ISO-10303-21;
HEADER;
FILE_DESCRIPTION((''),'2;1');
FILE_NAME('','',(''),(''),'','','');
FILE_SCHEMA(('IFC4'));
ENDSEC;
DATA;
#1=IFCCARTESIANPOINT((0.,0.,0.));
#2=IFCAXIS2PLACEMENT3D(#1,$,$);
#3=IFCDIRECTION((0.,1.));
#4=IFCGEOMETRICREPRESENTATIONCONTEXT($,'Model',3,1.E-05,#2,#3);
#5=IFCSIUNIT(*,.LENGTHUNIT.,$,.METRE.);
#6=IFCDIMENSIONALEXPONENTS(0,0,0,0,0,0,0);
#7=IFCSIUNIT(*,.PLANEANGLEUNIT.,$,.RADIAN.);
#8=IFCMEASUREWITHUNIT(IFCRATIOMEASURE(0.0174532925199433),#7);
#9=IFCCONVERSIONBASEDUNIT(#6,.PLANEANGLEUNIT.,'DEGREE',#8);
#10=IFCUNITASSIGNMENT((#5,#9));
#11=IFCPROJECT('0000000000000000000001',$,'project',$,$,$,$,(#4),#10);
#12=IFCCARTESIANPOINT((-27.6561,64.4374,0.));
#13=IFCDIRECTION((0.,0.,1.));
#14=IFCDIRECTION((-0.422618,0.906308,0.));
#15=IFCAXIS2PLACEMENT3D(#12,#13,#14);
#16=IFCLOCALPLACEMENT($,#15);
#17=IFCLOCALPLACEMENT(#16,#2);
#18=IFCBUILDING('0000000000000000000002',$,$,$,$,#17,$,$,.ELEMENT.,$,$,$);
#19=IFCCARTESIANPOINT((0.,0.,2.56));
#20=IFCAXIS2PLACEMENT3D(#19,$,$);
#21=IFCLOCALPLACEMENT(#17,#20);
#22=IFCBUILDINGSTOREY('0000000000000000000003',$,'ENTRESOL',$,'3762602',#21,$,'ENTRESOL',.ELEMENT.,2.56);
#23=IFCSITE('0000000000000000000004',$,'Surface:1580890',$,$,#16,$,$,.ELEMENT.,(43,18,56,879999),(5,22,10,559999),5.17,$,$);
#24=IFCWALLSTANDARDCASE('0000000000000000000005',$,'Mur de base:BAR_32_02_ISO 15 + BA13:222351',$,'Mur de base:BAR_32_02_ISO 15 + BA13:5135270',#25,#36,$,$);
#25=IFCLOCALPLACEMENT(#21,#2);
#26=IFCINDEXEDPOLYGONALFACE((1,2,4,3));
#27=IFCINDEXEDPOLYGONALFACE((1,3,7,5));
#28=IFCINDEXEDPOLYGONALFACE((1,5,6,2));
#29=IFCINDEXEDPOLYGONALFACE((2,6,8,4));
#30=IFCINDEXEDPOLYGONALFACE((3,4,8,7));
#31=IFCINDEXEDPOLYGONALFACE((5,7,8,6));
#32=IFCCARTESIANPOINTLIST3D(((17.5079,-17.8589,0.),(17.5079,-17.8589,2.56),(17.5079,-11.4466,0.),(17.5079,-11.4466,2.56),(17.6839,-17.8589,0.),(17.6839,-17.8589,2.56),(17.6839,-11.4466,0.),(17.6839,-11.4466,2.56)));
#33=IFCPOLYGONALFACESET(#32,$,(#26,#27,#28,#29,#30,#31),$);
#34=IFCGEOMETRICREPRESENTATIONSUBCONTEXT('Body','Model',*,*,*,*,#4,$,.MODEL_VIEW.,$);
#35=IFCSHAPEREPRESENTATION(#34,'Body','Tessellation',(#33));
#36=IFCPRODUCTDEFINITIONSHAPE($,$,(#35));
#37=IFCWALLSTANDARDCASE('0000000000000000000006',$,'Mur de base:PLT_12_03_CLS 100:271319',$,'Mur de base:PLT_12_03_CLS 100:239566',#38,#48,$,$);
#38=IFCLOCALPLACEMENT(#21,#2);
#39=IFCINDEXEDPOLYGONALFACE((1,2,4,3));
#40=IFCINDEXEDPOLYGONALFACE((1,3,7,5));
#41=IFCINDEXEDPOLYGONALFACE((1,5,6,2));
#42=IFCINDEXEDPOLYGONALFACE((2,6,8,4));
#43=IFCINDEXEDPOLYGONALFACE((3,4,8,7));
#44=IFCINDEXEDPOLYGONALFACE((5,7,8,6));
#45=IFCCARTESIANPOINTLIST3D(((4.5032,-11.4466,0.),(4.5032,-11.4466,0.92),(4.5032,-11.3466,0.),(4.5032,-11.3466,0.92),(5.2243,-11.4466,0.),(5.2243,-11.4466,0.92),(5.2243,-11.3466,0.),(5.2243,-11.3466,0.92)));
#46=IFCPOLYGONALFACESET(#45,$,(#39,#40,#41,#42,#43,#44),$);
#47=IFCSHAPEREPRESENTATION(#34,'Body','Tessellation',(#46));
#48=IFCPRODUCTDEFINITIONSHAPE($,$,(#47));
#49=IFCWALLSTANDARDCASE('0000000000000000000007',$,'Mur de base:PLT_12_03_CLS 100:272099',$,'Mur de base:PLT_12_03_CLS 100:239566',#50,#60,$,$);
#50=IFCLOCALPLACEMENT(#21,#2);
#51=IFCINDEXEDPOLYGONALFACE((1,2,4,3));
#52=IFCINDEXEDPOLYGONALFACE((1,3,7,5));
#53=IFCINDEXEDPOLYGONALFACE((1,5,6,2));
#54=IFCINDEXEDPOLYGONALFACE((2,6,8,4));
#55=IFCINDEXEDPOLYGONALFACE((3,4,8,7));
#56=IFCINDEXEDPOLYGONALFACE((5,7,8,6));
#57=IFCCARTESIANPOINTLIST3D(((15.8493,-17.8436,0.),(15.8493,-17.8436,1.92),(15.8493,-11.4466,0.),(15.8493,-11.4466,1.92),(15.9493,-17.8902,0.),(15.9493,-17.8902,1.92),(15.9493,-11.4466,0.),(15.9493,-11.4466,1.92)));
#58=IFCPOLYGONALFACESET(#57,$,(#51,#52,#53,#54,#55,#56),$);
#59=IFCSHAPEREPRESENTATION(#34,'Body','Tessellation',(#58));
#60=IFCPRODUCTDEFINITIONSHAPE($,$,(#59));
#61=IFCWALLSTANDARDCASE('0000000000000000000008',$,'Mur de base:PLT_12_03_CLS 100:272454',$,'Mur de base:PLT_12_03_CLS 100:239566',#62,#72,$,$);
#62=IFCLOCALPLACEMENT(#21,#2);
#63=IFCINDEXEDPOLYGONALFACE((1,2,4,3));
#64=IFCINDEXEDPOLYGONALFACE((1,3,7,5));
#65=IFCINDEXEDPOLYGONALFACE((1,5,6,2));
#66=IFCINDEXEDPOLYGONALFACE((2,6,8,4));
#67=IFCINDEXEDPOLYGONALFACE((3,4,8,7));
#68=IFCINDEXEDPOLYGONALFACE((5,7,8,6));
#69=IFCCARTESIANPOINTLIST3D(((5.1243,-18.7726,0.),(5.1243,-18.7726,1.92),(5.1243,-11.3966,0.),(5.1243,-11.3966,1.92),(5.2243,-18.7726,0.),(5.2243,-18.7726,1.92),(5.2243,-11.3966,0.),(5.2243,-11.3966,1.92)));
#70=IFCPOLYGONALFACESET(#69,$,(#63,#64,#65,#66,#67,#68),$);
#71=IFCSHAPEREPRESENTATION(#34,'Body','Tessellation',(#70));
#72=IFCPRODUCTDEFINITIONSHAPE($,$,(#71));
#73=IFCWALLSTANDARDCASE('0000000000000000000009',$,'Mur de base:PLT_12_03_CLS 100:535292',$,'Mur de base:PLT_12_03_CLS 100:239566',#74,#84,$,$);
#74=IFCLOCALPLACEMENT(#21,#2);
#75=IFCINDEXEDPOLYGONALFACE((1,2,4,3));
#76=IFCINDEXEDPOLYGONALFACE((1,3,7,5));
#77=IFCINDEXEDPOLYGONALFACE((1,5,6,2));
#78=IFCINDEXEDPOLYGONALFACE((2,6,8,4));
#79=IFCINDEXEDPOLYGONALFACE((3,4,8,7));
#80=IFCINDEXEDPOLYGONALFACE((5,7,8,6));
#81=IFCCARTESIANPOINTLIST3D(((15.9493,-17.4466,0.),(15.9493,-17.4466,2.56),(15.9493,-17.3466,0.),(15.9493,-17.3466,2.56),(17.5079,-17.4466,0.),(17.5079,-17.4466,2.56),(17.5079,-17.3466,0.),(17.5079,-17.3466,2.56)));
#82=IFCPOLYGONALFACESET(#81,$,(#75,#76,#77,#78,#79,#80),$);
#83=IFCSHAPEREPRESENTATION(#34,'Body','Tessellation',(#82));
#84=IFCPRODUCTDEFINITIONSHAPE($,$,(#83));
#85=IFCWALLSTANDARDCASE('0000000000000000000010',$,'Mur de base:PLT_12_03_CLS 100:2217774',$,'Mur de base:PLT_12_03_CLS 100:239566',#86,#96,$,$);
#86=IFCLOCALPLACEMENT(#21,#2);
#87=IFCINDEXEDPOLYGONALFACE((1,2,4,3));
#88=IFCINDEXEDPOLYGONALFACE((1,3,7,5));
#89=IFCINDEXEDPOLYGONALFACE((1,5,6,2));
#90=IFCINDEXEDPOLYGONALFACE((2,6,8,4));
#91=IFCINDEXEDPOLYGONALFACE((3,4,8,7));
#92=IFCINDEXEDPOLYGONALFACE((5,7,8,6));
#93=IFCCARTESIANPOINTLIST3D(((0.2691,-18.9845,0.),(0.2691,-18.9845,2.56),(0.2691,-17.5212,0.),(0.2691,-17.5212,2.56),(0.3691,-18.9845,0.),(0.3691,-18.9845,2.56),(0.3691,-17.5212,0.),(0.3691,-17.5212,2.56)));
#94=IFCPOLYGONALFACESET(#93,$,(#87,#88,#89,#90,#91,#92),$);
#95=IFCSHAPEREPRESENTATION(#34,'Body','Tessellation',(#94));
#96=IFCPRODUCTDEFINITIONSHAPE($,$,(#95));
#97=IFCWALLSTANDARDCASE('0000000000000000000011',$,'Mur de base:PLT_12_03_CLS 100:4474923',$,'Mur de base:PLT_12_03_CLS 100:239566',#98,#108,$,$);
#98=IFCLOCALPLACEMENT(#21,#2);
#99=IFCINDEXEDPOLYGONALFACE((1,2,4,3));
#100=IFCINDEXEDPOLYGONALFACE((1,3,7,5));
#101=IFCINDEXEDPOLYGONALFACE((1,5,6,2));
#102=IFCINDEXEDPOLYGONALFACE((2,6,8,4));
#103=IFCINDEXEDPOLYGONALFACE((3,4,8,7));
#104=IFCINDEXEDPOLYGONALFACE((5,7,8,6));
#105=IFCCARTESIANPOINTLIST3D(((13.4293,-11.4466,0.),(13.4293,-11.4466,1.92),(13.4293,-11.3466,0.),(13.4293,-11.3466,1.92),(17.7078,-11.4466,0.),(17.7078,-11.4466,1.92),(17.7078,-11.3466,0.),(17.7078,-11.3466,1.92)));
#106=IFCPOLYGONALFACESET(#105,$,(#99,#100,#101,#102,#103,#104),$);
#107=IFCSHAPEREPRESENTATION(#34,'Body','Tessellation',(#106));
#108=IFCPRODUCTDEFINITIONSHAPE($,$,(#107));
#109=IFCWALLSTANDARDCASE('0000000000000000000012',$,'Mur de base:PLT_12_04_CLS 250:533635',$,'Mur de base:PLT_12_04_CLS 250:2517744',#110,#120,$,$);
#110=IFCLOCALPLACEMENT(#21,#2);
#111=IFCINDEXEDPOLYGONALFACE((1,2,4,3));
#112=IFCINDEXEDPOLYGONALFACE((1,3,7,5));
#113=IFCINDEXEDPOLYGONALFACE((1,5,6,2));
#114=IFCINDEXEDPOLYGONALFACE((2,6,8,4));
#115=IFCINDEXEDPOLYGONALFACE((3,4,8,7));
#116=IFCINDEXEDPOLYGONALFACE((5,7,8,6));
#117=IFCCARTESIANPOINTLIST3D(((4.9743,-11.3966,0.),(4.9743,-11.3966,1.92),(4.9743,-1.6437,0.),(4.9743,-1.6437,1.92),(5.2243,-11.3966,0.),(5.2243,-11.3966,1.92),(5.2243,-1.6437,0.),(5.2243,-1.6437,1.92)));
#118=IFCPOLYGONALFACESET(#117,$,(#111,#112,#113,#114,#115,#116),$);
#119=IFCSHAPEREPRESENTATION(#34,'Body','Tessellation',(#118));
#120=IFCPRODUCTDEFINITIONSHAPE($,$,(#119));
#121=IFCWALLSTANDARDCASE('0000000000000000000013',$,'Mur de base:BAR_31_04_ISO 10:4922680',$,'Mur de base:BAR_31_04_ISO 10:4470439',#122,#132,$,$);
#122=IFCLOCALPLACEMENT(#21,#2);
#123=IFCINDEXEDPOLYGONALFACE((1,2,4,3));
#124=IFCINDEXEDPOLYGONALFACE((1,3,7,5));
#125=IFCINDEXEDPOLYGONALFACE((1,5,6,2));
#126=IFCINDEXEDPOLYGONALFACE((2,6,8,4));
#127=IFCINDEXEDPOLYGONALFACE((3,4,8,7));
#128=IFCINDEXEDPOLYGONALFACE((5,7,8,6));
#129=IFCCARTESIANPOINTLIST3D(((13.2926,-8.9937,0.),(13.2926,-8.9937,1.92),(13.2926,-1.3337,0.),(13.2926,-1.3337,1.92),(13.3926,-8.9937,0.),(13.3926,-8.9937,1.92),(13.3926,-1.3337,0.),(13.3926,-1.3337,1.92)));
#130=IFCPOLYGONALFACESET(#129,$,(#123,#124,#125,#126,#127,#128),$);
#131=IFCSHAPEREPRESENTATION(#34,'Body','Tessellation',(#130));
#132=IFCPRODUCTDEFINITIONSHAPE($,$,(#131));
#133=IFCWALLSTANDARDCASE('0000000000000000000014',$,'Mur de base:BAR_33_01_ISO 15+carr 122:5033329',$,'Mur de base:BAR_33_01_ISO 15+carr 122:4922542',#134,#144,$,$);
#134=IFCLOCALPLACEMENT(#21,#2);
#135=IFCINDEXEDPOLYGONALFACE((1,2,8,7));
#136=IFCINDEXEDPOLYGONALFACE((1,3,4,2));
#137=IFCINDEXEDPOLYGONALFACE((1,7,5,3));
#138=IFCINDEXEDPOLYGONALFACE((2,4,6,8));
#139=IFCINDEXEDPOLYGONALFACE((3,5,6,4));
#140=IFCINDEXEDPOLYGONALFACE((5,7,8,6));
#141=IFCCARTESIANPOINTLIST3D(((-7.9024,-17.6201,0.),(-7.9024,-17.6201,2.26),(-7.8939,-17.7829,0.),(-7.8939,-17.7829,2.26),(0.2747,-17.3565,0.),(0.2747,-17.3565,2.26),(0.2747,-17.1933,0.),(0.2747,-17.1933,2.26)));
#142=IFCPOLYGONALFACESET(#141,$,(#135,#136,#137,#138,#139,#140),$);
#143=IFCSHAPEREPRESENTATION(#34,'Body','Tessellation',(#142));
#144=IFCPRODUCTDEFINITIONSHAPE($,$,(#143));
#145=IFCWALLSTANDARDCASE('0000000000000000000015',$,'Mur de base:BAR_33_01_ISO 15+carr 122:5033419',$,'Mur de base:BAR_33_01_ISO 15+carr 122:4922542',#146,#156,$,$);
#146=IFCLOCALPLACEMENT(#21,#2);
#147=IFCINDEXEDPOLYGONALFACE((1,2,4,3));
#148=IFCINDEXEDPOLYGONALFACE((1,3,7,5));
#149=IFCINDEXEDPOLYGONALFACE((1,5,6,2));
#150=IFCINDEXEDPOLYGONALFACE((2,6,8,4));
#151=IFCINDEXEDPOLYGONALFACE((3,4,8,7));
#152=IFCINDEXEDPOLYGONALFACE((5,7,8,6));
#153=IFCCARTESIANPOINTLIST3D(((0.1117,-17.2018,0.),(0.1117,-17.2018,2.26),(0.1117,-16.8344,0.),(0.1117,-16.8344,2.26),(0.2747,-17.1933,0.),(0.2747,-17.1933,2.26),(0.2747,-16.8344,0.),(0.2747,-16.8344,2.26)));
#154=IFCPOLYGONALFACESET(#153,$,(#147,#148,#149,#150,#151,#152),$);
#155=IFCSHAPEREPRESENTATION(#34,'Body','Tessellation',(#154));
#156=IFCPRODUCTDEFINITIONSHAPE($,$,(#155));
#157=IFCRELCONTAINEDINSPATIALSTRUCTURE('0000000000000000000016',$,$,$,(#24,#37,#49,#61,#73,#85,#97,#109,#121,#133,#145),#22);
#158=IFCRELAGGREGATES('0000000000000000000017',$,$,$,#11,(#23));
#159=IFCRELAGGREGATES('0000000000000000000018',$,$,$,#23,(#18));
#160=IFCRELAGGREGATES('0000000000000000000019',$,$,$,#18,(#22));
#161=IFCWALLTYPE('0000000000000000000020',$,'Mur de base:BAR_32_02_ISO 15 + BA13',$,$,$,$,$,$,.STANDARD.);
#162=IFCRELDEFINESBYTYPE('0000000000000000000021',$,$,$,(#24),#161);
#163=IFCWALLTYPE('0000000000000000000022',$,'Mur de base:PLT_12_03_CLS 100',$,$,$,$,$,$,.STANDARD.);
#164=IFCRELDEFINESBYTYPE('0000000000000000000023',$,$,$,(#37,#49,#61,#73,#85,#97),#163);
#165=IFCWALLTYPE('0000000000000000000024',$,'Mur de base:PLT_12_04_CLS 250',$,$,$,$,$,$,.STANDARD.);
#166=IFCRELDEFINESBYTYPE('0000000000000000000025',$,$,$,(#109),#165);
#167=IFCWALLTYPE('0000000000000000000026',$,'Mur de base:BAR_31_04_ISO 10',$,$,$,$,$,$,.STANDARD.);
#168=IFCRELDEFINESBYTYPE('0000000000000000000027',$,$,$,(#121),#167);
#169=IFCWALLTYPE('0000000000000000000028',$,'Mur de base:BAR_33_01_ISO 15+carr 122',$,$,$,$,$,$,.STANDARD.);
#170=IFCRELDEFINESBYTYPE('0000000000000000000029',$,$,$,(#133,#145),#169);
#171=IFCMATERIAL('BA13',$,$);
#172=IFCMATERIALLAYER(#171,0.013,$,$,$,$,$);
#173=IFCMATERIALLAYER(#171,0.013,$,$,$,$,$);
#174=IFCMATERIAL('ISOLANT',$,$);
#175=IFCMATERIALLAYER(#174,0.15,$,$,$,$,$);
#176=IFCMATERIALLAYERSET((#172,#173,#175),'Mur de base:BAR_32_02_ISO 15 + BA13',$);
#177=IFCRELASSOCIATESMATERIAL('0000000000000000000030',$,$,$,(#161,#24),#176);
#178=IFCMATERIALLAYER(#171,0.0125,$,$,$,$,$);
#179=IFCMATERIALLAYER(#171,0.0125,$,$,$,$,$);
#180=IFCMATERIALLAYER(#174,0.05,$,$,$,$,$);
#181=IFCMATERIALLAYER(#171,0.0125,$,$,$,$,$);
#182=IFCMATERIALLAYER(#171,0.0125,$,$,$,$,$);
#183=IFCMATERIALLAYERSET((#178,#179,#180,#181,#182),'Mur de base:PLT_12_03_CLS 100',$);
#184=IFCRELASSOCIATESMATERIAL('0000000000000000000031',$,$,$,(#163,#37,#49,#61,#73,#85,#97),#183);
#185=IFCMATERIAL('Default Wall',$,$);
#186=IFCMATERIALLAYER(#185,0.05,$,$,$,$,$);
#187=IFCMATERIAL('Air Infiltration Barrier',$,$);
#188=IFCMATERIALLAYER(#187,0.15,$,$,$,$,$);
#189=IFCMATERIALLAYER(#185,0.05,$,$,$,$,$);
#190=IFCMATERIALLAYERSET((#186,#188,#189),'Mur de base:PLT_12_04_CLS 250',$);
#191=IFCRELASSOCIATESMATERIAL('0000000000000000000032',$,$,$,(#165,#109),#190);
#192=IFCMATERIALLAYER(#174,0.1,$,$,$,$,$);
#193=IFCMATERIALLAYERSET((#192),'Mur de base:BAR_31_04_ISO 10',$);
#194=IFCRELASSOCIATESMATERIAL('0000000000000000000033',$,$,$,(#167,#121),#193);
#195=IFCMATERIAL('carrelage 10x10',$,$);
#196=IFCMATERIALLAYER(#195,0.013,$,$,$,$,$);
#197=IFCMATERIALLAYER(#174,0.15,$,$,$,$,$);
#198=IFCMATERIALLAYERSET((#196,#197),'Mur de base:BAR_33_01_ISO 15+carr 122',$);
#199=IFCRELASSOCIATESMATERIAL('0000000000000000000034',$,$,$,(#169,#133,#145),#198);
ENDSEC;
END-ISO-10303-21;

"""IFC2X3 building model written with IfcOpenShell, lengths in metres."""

from ifc_helpers import new_model, entity, si_unit, converted_unit, direction, frame, frame_2d, origin, place, context, subcontext, project, spatial, polyline, rectangle, outline, extrude, clip, halfspace, bounded_halfspace, material, layer, layer_set, layer_usage, type_object, element, save


model = new_model("IFC2X3")

# Units and contexts
model_context = context("Model", 3, precision=1e-05, world=origin(), true_north=direction((0.0, 1.0)))
body_context = subcontext(model_context, "Body", "Model", "MODEL_VIEW")
ifc_project = project(units=[si_unit("LENGTHUNIT", "METRE"), converted_unit("PLANEANGLEUNIT", "DEGREE", entity("IfcRatioMeasure", 0.0174532925199433), si_unit("PLANEANGLEUNIT", "RADIAN"), dimensions=[0, 0, 0, 0, 0, 0, 0])], contexts=[model_context])

# Site, building, storey
site_placement = place(None, frame((-27.6561, 64.4374, 0.0), z_axis=(0.0, 0.0, 1.0), x_axis=(-0.422618, 0.906308, 0.0)))
site = spatial("IfcSite", under=ifc_project, at=site_placement, Name="Surface:1580890", CompositionType="ELEMENT", RefLatitude=(43, 18, 56, 879999), RefLongitude=(5, 22, 10, 559999), RefElevation=5.17)
building_placement = place(site_placement, origin())
building = spatial("IfcBuilding", under=site, at=building_placement, CompositionType="ELEMENT")
storey_placement = place(building_placement, frame((0.0, 0.0, 2.56)))
storey = spatial("IfcBuildingStorey", under=building, at=storey_placement, Name="ENTRESOL", ObjectType="3762602", LongName="ENTRESOL", CompositionType="ELEMENT", Elevation=2.56)

# Walls
ifc_material_1 = material(Name="BA13")
ifc_layer_1 = layer(ifc_material_1, 0.013)
ifc_layer_2 = layer(ifc_material_1, 0.013)
ifc_material_2 = material(Name="ISOLANT")
ifc_layer_3 = layer(ifc_material_2, 0.15)
ifc_layer_set_1 = layer_set([ifc_layer_1, ifc_layer_2, ifc_layer_3], Name="Mur de base:BAR_32_02_ISO 15 + BA13")
ifc_layer_usage_1 = layer_usage(ifc_layer_set_1, "AXIS2", "NEGATIVE", 0.088)
wall_type_1 = type_object("IfcWallType", Name="Mur de base:BAR_32_02_ISO 15 + BA13", PredefinedType="STANDARD", material=ifc_layer_set_1)
wall_1_placement = place(storey_placement, frame((17.5959, -17.8589, 0.0), z_axis=(0.0, 0.0, 1.0), x_axis=(0.0, 1.0, 0.0)))
element("IfcWallStandardCase", 1, at=wall_1_placement, inside=storey, type_object=wall_type_1, material=ifc_layer_usage_1, Name="Mur de base:BAR_32_02_ISO 15 + BA13:222351", ObjectType="Mur de base:BAR_32_02_ISO 15 + BA13:5135270", context=body_context, shape_type="Clipping", body=[
    clip(extrude(rectangle(XDim=6.4123, YDim=0.176, at=frame_2d((3.2062, 0.0), x_axis=(-1.0, 0.0))), origin(), (0.0, 0.0, 1.0), 2.56), halfspace(frame((0.0, 0.0, -2.56)), True)),
])
ifc_layer_4 = layer(ifc_material_1, 0.0125)
ifc_layer_5 = layer(ifc_material_1, 0.0125)
ifc_layer_6 = layer(ifc_material_2, 0.05)
ifc_layer_7 = layer(ifc_material_1, 0.0125)
ifc_layer_8 = layer(ifc_material_1, 0.0125)
ifc_layer_set_2 = layer_set([ifc_layer_4, ifc_layer_5, ifc_layer_6, ifc_layer_7, ifc_layer_8], Name="Mur de base:PLT_12_03_CLS 100")
ifc_layer_usage_2 = layer_usage(ifc_layer_set_2, "AXIS2", "NEGATIVE", 0.05)
wall_type_2 = type_object("IfcWallType", Name="Mur de base:PLT_12_03_CLS 100", PredefinedType="STANDARD", material=ifc_layer_set_2)
wall_2_placement = place(storey_placement, frame((4.5032, -11.3966, 0.0)))
element("IfcWallStandardCase", 2, at=wall_2_placement, inside=storey, type_object=wall_type_2, material=ifc_layer_usage_2, Name="Mur de base:PLT_12_03_CLS 100:271319", ObjectType="Mur de base:PLT_12_03_CLS 100:239566", context=body_context, shape_type="Clipping", body=[
    clip(extrude(rectangle(XDim=0.7212, YDim=0.1, at=frame_2d((0.3606, 0.0), x_axis=(-1.0, 0.0))), origin(), (0.0, 0.0, 1.0), 0.92), halfspace(frame((0.0, 0.0, -2.56)), True)),
])
ifc_layer_usage_3 = layer_usage(ifc_layer_set_2, "AXIS2", "NEGATIVE", 0.05)
wall_3_placement = place(storey_placement, frame((15.8993, -11.4466, 0.0), z_axis=(0.0, 0.0, 1.0), x_axis=(0.0, -1.0, 0.0)))
element("IfcWallStandardCase", 3, at=wall_3_placement, inside=storey, type_object=wall_type_2, material=ifc_layer_usage_3, Name="Mur de base:PLT_12_03_CLS 100:272099", ObjectType="Mur de base:PLT_12_03_CLS 100:239566", context=body_context, shape_type="Clipping", body=[
    clip(clip(extrude(outline(polyline([(0.0, -0.05), (0.1471, -0.05), (6.397, -0.05), (6.4436, 0.05), (0.1471, 0.05), (0.0, 0.05), (0.0, -0.05)])), origin(), (0.0, 0.0, 1.0), 1.92), bounded_halfspace(frame((0.0, -0.05, 1.92), z_axis=(0.0, 0.0, 1.0), x_axis=(0.0, -1.0, 0.0)), False, frame((0.0, -0.05, 1.92)), polyline([(0.0, 0.0), (0.1471, 0.0), (6.397, 0.0), (6.4436, 0.1), (0.1471, 0.1), (0.0, 0.1), (0.0, 0.0)]))), halfspace(frame((0.0, 0.0, -2.56)), True)),
])
ifc_layer_usage_4 = layer_usage(ifc_layer_set_2, "AXIS2", "NEGATIVE", 0.05)
wall_4_placement = place(storey_placement, frame((5.1743, -11.3966, 0.0), z_axis=(0.0, 0.0, 1.0), x_axis=(0.0, -1.0, 0.0)))
element("IfcWallStandardCase", 4, at=wall_4_placement, inside=storey, type_object=wall_type_2, material=ifc_layer_usage_4, Name="Mur de base:PLT_12_03_CLS 100:272454", ObjectType="Mur de base:PLT_12_03_CLS 100:239566", context=body_context, shape_type="Clipping", body=[
    clip(extrude(rectangle(XDim=7.376, YDim=0.1, at=frame_2d((3.688, 0.0), x_axis=(1.0, 0.0))), origin(), (0.0, 0.0, 1.0), 1.92), halfspace(frame((0.0, 0.0, -2.56)), True)),
])
ifc_layer_usage_5 = layer_usage(ifc_layer_set_2, "AXIS2", "NEGATIVE", 0.05)
wall_5_placement = place(storey_placement, frame((15.9493, -17.3966, 0.0)))
element("IfcWallStandardCase", 5, at=wall_5_placement, inside=storey, type_object=wall_type_2, material=ifc_layer_usage_5, Name="Mur de base:PLT_12_03_CLS 100:535292", ObjectType="Mur de base:PLT_12_03_CLS 100:239566", context=body_context, shape_type="Clipping", body=[
    clip(extrude(rectangle(XDim=1.5586, YDim=0.1, at=frame_2d((0.7793, 0.0), x_axis=(-1.0, 0.0))), origin(), (0.0, 0.0, 1.0), 2.56), halfspace(frame((0.0, 0.0, -2.56)), True)),
])
ifc_layer_usage_6 = layer_usage(ifc_layer_set_2, "AXIS2", "NEGATIVE", 0.05)
wall_6_placement = place(storey_placement, frame((0.3191, -17.5212, 0.0), z_axis=(0.0, 0.0, 1.0), x_axis=(0.0, -1.0, 0.0)))
element("IfcWallStandardCase", 6, at=wall_6_placement, inside=storey, type_object=wall_type_2, material=ifc_layer_usage_6, Name="Mur de base:PLT_12_03_CLS 100:2217774", ObjectType="Mur de base:PLT_12_03_CLS 100:239566", context=body_context, shape_type="Clipping", body=[
    clip(extrude(rectangle(XDim=1.4633, YDim=0.1, at=frame_2d((0.7316, 0.0), x_axis=(-1.0, 0.0))), origin(), (0.0, 0.0, 1.0), 2.56), halfspace(frame((0.0, 0.0, -2.56)), True)),
])
ifc_layer_usage_7 = layer_usage(ifc_layer_set_2, "AXIS2", "NEGATIVE", 0.05)
wall_7_placement = place(storey_placement, frame((13.4293, -11.3966, 0.0)))
element("IfcWallStandardCase", 7, at=wall_7_placement, inside=storey, type_object=wall_type_2, material=ifc_layer_usage_7, Name="Mur de base:PLT_12_03_CLS 100:4474923", ObjectType="Mur de base:PLT_12_03_CLS 100:239566", context=body_context, shape_type="Clipping", body=[
    clip(clip(extrude(rectangle(XDim=4.2784, YDim=0.1, at=frame_2d((2.1392, 0.0), x_axis=(-1.0, 0.0))), origin(), (0.0, 0.0, 1.0), 1.92), bounded_halfspace(frame((0.0, -0.05, 1.92), z_axis=(0.0, 0.0, 1.0), x_axis=(-1.0, 0.0, 0.0)), False, frame((0.0, -0.05, 1.92)), polyline([(0.0, 0.0), (2.42, 0.0), (2.52, 0.0), (4.2784, 0.0), (4.2784, 0.1), (0.0, 0.1), (0.0, 0.0)]))), halfspace(frame((0.0, 0.0, -2.56)), True)),
])
ifc_material_3 = material(Name="Default Wall")
ifc_layer_9 = layer(ifc_material_3, 0.05)
ifc_material_4 = material(Name="Air Infiltration Barrier")
ifc_layer_10 = layer(ifc_material_4, 0.15)
ifc_layer_11 = layer(ifc_material_3, 0.05)
ifc_layer_set_3 = layer_set([ifc_layer_9, ifc_layer_10, ifc_layer_11], Name="Mur de base:PLT_12_04_CLS 250")
ifc_layer_usage_8 = layer_usage(ifc_layer_set_3, "AXIS2", "NEGATIVE", 0.125)
wall_type_3 = type_object("IfcWallType", Name="Mur de base:PLT_12_04_CLS 250", PredefinedType="STANDARD", material=ifc_layer_set_3)
wall_8_placement = place(storey_placement, frame((5.0993, -1.6437, 0.0), z_axis=(0.0, 0.0, 1.0), x_axis=(0.0, -1.0, 0.0)))
element("IfcWallStandardCase", 8, at=wall_8_placement, inside=storey, type_object=wall_type_3, material=ifc_layer_usage_8, Name="Mur de base:PLT_12_04_CLS 250:533635", ObjectType="Mur de base:PLT_12_04_CLS 250:2517744", context=body_context, shape_type="Clipping", body=[
    clip(clip(extrude(rectangle(XDim=9.7529, YDim=0.25, at=frame_2d((4.8764, 0.0), x_axis=(-1.0, 0.0))), origin(), (0.0, 0.0, 1.0), 1.92), bounded_halfspace(frame((0.0, -0.125, 1.92), z_axis=(0.0, 0.0, 1.0), x_axis=(0.0, -1.0, 0.0)), False, frame((0.0, -0.125, 1.92)), polyline([(0.0, 0.0), (9.7529, 0.0), (9.7529, 0.15), (9.7529, 0.25), (0.0, 0.25), (0.0, 0.0)]))), halfspace(frame((0.0, 0.0, -2.56)), True)),
])
ifc_layer_12 = layer(ifc_material_2, 0.1)
ifc_layer_set_4 = layer_set([ifc_layer_12], Name="Mur de base:BAR_31_04_ISO 10")
ifc_layer_usage_9 = layer_usage(ifc_layer_set_4, "AXIS2", "NEGATIVE", 0.05)
wall_type_4 = type_object("IfcWallType", Name="Mur de base:BAR_31_04_ISO 10", PredefinedType="STANDARD", material=ifc_layer_set_4)
wall_9_placement = place(storey_placement, frame((13.3426, -8.9937, 0.0), z_axis=(0.0, 0.0, 1.0), x_axis=(0.0, 1.0, 0.0)))
element("IfcWallStandardCase", 9, at=wall_9_placement, inside=storey, type_object=wall_type_4, material=ifc_layer_usage_9, Name="Mur de base:BAR_31_04_ISO 10:4922680", ObjectType="Mur de base:BAR_31_04_ISO 10:4470439", context=body_context, shape_type="Clipping", body=[
    clip(extrude(rectangle(XDim=7.66, YDim=0.1, at=frame_2d((3.83, 0.0), x_axis=(-1.0, 0.0))), origin(), (0.0, 0.0, 1.0), 1.92), halfspace(frame((0.0, 0.0, -2.56)), True)),
])
ifc_material_5 = material(Name="carrelage 10x10")
ifc_layer_13 = layer(ifc_material_5, 0.013)
ifc_layer_14 = layer(ifc_material_2, 0.15)
ifc_layer_set_5 = layer_set([ifc_layer_13, ifc_layer_14], Name="Mur de base:BAR_33_01_ISO 15+carr 122")
ifc_layer_usage_10 = layer_usage(ifc_layer_set_5, "AXIS2", "NEGATIVE", 0.0815)
wall_type_5 = type_object("IfcWallType", Name="Mur de base:BAR_33_01_ISO 15+carr 122", PredefinedType="STANDARD", material=ifc_layer_set_5)
wall_10_placement = place(storey_placement, frame((-7.8981, -17.7015, 0.0), z_axis=(0.0, 0.0, 1.0), x_axis=(0.998641, 0.05212, 0.0)))
element("IfcWallStandardCase", 10, at=wall_10_placement, inside=storey, type_object=wall_type_5, material=ifc_layer_usage_10, Name="Mur de base:BAR_33_01_ISO 15+carr 122:5033329", ObjectType="Mur de base:BAR_33_01_ISO 15+carr 122:4922542", context=body_context, shape_type="Clipping", body=[
    clip(extrude(outline(polyline([(8.1797, -0.0815), (8.1882, 0.0815), (0.0, 0.0815), (0.0, -0.0815), (8.1797, -0.0815)])), origin(), (0.0, 0.0, 1.0), 2.26), halfspace(frame((0.0, 0.0, -2.56)), True)),
])
ifc_layer_usage_11 = layer_usage(ifc_layer_set_5, "AXIS2", "NEGATIVE", 0.0815)
wall_11_placement = place(storey_placement, frame((0.1932, -17.2018, 0.0), z_axis=(0.0, 0.0, 1.0), x_axis=(0.0, 1.0, 0.0)))
element("IfcWallStandardCase", 11, at=wall_11_placement, inside=storey, type_object=wall_type_5, material=ifc_layer_usage_11, Name="Mur de base:BAR_33_01_ISO 15+carr 122:5033419", ObjectType="Mur de base:BAR_33_01_ISO 15+carr 122:4922542", context=body_context, shape_type="Clipping", body=[
    clip(extrude(outline(polyline([(0.3674, -0.0815), (0.3674, 0.0815), (0.0, 0.0815), (0.0085, -0.0815), (0.3674, -0.0815)])), origin(), (0.0, 0.0, 1.0), 2.26), halfspace(frame((0.0, 0.0, -2.56)), True)),
])

save(model, "model.ifc")
